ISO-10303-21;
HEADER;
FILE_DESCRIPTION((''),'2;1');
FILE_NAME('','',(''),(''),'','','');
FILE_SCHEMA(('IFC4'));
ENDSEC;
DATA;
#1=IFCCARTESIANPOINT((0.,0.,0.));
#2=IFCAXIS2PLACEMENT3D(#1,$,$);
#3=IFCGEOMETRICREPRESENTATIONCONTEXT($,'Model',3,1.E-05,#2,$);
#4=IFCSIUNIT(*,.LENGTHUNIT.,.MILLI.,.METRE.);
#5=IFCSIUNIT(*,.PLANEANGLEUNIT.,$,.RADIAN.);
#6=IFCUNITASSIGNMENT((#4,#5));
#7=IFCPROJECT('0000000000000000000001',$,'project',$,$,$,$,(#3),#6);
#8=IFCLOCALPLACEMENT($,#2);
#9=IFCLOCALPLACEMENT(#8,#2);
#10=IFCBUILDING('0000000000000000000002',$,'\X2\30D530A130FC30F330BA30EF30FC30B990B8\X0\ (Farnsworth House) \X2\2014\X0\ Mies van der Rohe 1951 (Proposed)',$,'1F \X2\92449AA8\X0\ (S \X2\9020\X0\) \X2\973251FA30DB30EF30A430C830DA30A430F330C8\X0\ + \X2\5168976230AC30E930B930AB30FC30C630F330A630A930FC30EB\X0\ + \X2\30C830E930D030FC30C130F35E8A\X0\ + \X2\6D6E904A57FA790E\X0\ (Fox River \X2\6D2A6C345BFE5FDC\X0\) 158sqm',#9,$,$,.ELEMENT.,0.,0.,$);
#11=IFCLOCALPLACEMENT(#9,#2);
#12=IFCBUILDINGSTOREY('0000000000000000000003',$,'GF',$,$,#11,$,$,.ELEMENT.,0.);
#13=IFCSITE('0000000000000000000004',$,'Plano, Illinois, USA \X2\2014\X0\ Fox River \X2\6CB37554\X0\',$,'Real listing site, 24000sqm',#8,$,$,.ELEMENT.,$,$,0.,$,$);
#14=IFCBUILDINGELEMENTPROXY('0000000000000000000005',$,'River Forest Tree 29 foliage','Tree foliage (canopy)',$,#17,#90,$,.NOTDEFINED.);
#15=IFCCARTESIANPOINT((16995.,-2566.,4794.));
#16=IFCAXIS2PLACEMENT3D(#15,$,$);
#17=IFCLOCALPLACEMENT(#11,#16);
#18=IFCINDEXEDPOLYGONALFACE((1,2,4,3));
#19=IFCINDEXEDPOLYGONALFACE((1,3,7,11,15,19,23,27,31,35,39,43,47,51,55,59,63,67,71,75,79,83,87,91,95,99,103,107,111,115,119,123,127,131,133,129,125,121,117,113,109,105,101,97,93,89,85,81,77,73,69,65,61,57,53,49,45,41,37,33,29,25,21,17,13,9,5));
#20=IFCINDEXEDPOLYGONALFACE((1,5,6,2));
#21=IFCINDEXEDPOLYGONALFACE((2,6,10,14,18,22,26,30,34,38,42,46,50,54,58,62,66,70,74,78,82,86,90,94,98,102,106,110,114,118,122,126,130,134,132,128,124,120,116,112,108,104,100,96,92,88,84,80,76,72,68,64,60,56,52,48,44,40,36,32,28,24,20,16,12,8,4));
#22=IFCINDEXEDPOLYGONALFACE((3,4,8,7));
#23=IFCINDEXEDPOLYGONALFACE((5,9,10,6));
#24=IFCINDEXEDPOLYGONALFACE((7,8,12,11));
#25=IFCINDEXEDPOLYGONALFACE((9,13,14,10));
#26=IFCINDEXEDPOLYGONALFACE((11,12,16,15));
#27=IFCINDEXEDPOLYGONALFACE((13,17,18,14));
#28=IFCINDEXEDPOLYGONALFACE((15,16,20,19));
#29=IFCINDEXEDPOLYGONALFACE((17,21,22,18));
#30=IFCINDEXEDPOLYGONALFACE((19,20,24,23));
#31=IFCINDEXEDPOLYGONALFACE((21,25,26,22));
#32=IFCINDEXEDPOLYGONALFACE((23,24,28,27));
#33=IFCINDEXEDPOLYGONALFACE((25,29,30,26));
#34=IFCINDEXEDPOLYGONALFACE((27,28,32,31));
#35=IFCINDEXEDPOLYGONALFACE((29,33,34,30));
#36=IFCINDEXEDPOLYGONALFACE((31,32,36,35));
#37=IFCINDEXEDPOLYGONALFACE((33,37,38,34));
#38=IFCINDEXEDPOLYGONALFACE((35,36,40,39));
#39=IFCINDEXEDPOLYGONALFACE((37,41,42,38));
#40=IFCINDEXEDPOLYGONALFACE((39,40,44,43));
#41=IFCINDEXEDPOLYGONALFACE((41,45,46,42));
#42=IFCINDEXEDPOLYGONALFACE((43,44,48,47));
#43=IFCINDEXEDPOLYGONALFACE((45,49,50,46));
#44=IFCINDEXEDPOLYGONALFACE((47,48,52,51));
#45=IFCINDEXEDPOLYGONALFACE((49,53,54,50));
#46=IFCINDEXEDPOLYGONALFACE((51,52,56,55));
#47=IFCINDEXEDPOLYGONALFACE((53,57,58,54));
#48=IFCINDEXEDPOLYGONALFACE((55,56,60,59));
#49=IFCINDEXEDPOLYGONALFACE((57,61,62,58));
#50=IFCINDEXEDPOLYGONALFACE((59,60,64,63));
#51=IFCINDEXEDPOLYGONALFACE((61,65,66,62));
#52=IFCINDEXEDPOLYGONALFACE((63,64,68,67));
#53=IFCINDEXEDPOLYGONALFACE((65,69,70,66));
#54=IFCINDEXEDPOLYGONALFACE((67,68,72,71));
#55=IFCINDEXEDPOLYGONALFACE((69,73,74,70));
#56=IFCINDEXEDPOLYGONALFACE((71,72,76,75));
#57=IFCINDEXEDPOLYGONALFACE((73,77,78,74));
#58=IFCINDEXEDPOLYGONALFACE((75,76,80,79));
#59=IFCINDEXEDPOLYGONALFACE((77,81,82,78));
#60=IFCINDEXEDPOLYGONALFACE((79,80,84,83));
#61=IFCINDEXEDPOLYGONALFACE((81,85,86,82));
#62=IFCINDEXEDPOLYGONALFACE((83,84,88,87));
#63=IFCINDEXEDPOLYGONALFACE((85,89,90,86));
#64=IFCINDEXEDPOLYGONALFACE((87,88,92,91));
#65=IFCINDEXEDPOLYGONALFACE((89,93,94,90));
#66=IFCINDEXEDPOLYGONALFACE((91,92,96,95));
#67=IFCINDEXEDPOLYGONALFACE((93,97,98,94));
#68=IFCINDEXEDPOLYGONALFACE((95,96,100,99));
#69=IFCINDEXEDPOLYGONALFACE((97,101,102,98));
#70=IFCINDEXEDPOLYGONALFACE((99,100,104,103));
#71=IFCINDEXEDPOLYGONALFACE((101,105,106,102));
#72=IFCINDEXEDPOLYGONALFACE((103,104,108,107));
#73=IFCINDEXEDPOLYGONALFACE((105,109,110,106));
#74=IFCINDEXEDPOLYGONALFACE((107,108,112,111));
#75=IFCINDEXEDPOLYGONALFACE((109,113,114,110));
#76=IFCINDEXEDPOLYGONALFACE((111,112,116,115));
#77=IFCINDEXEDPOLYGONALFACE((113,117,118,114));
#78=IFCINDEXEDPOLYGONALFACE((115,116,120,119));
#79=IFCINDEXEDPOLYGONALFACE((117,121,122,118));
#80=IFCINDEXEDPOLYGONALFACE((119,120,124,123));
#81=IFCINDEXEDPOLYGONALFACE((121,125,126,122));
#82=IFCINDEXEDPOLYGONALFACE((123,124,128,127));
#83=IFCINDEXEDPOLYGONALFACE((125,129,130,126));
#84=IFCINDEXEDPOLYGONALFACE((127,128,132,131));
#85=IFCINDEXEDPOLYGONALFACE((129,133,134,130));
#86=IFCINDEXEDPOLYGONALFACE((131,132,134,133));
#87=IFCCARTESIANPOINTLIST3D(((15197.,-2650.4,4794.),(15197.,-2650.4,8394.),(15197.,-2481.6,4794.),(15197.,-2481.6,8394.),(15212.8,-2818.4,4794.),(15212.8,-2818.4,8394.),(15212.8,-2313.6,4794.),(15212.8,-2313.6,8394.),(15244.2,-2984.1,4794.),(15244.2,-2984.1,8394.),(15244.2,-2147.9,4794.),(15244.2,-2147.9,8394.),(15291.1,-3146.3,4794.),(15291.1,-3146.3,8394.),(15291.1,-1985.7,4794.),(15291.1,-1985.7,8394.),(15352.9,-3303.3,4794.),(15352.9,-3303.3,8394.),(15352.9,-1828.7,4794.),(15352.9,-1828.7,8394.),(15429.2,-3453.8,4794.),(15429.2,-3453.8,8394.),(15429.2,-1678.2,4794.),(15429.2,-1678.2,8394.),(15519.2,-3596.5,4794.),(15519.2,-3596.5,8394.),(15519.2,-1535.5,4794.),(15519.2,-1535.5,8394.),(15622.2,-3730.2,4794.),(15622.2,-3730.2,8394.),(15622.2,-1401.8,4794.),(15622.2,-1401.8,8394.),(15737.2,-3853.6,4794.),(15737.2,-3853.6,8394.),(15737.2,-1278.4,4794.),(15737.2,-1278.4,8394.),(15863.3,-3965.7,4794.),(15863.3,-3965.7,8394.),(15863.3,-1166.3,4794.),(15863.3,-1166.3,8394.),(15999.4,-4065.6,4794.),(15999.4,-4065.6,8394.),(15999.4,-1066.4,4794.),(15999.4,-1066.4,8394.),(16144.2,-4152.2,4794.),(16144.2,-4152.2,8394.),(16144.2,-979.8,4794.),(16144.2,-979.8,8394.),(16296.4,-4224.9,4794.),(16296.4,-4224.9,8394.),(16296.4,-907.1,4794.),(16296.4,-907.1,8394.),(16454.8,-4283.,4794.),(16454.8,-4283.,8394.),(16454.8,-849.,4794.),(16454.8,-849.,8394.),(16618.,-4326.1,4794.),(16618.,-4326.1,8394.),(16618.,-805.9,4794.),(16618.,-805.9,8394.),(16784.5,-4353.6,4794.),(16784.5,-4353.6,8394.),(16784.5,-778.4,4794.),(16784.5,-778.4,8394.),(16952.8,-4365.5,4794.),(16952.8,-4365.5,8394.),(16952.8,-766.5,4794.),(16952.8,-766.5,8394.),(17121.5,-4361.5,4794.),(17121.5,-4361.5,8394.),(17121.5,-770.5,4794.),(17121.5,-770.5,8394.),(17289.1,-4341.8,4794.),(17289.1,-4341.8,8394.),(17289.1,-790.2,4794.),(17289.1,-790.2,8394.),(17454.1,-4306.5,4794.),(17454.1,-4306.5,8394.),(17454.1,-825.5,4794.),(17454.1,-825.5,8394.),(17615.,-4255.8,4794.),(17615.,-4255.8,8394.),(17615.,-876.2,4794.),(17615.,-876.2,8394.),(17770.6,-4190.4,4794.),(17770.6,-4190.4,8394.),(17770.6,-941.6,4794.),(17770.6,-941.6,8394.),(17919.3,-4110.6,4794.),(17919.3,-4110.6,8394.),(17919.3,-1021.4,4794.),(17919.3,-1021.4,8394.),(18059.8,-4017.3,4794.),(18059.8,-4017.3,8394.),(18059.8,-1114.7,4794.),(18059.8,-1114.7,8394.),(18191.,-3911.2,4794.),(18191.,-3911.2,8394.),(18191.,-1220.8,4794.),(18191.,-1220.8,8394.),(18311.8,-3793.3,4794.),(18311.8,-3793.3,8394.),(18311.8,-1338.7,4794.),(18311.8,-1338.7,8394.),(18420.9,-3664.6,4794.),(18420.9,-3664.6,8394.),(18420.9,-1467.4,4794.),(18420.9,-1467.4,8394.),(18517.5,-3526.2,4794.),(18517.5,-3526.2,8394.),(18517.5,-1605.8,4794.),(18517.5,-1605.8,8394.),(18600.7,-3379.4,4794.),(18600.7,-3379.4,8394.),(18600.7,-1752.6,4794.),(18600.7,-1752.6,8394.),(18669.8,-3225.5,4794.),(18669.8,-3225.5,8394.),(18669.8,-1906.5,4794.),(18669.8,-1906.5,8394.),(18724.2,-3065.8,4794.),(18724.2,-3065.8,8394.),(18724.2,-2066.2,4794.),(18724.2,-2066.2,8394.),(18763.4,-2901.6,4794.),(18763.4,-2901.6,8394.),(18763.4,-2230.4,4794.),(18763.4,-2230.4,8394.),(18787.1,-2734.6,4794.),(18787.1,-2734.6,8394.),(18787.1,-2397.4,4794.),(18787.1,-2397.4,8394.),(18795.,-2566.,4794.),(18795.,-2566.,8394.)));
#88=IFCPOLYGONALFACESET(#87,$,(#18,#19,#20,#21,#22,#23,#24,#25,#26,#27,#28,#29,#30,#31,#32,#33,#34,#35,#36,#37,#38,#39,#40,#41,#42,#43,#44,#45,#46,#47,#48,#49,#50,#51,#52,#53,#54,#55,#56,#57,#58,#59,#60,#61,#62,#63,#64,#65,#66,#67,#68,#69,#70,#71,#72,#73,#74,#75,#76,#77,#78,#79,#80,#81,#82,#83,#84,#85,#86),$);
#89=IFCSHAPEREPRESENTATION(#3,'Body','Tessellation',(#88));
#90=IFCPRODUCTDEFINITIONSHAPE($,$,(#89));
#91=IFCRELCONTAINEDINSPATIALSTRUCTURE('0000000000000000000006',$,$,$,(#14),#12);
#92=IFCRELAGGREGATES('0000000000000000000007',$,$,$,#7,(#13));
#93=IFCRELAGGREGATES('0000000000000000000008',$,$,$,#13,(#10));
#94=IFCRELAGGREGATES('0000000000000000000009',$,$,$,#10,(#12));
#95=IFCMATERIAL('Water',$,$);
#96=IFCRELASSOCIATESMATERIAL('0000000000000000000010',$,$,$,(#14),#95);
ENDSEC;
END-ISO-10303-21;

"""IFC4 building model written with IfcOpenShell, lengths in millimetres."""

from ifc_helpers import new_model, si_unit, frame, origin, origin_2d, place, context, project, spatial, circle, extrude, material, element, save


model = new_model("IFC4")

# Units and contexts
model_context = context("Model", 3, precision=1e-05, world=origin())
ifc_project = project(units=[si_unit("LENGTHUNIT", "METRE", prefix="MILLI"), si_unit("PLANEANGLEUNIT", "RADIAN")], contexts=[model_context])

# Site, building, storey
site_placement = place(None, origin())
site = spatial("IfcSite", under=ifc_project, at=site_placement, Name="Plano, Illinois, USA — Fox River 河畔", ObjectType="Real listing site, 24000sqm", CompositionType="ELEMENT", RefElevation=0.0)
building_placement = place(site_placement, origin())
building = spatial("IfcBuilding", under=site, at=building_placement, Name="ファーンズワース邸 (Farnsworth House) — Mies van der Rohe 1951 (Proposed)", ObjectType="1F 鉄骨 (S 造) 露出ホワイトペイント + 全面ガラスカーテンウォール + トラバーチン床 + 浮遊基礎 (Fox River 洪水対応) 158sqm", CompositionType="ELEMENT", ElevationOfRefHeight=0.0, ElevationOfTerrain=0.0)
storey_placement = place(building_placement, origin())
storey = spatial("IfcBuildingStorey", under=building, at=storey_placement, Name="GF", CompositionType="ELEMENT", Elevation=0.0)

# Building element proxy
ifc_material_1 = material(Name="Water")
proxy_1_placement = place(storey_placement, frame((16995.0, -2566.0, 4794.0)))
element("IfcBuildingElementProxy", 1, at=proxy_1_placement, inside=storey, material=ifc_material_1, Name="River Forest Tree 29 foliage", Description="Tree foliage (canopy)", PredefinedType="NOTDEFINED", context=model_context, shape_type="SweptSolid", body=[
    extrude(circle(Radius=1800.0, at=origin_2d()), frame((16995.0, -2566.0, 4794.0)), (0.0, 0.0, 1.0), 3600.0),
])

save(model, "model.ifc")
